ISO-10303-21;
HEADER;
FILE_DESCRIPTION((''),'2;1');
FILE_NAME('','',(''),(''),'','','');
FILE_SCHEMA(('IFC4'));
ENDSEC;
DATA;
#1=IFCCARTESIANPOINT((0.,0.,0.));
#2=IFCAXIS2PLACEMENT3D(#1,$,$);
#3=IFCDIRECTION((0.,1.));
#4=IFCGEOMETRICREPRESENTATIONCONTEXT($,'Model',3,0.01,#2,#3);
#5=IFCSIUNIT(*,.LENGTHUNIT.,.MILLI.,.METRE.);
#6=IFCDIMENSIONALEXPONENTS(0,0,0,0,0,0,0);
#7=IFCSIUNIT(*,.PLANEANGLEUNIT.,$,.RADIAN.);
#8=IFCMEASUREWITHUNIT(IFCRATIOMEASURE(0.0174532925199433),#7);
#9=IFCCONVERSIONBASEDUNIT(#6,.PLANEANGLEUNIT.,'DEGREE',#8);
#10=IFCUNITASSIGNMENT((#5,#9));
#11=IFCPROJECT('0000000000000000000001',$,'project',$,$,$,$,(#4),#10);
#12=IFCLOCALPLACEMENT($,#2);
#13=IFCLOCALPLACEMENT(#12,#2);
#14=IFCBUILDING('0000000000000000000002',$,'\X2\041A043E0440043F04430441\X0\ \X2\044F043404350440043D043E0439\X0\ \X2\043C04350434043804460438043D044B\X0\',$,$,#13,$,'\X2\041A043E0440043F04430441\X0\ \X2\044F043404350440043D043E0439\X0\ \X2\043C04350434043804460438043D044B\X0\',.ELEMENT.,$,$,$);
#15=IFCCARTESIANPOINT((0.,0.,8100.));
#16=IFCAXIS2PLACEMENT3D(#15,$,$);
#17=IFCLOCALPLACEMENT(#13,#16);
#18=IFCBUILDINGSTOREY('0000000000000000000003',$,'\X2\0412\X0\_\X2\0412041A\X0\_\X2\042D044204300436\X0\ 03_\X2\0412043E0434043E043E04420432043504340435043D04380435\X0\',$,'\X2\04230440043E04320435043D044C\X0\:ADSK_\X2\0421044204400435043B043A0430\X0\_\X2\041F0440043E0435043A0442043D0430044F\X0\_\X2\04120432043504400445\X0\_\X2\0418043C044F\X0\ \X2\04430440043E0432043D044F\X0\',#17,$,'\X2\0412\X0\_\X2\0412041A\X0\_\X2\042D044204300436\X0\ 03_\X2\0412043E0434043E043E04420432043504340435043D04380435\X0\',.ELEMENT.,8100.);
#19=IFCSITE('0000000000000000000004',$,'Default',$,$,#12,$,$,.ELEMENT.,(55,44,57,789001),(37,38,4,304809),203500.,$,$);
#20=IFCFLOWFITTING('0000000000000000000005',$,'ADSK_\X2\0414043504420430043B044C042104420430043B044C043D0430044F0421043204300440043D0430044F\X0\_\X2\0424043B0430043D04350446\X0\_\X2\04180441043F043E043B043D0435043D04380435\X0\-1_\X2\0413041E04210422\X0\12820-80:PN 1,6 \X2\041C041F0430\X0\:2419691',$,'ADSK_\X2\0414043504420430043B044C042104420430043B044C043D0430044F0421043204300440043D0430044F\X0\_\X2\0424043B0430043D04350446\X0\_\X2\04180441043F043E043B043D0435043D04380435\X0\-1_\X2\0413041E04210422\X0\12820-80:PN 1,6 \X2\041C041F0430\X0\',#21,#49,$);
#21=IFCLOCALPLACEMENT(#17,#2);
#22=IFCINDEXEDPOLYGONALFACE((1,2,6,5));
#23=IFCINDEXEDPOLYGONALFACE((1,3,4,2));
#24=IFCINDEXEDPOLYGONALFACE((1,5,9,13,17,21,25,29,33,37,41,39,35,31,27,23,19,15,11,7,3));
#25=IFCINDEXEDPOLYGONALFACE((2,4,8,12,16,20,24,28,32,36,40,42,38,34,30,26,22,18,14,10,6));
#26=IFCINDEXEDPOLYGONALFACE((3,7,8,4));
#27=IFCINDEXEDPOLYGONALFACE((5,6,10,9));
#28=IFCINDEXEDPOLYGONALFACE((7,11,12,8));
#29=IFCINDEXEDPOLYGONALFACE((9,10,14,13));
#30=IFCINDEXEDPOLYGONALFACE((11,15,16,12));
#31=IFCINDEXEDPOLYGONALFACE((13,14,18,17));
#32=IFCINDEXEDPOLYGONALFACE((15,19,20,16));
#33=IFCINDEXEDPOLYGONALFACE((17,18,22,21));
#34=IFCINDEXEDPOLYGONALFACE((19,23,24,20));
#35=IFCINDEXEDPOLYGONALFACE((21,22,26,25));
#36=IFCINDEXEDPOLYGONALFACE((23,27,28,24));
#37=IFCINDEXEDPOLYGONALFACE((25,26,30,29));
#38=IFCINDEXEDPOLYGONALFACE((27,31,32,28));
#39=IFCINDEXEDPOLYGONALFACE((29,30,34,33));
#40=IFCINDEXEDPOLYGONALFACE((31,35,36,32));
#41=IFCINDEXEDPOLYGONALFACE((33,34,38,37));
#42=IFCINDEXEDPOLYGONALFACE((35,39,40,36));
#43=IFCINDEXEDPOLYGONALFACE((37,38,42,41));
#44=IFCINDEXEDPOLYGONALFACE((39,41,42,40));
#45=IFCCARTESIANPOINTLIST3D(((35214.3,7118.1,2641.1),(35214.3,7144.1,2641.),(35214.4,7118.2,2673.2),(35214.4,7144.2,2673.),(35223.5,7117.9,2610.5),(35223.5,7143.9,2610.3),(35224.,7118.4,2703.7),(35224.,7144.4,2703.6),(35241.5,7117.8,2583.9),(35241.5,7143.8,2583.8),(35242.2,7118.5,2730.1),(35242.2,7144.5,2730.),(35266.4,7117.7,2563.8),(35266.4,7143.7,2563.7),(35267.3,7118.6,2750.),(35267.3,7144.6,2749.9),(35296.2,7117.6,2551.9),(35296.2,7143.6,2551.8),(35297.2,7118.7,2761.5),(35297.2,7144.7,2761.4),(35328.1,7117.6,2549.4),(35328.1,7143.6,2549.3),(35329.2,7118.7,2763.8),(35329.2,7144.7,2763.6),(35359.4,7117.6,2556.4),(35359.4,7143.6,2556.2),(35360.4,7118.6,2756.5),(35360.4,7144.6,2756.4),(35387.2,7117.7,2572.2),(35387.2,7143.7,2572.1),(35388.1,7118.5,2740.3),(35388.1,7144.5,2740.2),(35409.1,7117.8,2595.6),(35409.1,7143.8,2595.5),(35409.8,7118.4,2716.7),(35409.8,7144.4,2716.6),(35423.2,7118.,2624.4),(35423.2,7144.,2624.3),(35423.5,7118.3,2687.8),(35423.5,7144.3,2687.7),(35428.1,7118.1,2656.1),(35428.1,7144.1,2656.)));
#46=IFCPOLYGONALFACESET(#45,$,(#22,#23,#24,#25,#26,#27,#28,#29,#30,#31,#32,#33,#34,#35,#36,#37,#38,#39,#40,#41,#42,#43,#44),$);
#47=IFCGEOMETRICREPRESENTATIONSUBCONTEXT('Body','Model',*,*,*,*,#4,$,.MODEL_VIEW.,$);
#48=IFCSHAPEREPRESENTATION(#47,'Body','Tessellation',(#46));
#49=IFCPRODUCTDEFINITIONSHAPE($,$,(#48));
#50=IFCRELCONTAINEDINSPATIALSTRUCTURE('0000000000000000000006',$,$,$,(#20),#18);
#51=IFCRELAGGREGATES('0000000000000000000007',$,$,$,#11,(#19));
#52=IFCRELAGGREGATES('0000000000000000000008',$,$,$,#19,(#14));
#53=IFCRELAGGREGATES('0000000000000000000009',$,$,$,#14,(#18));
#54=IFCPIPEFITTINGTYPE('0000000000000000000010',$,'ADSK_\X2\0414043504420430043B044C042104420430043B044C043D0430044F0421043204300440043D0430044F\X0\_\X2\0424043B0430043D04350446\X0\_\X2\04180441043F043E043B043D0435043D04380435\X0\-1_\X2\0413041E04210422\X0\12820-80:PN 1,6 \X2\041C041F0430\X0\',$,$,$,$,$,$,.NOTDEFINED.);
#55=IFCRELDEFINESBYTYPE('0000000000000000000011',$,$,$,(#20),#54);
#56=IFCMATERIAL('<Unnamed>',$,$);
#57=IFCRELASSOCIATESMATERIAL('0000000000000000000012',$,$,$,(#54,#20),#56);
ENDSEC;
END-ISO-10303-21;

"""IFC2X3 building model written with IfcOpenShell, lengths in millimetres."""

from ifc_helpers import new_model, entity, si_unit, converted_unit, direction, frame, origin, origin_2d_with_axis, place, context, subcontext, project, spatial, circle, extrude, source, transform, mapped, material, type_object, type_shapes, element, save


model = new_model("IFC2X3")

# Units and contexts
model_context = context("Model", 3, precision=0.01, world=origin(), true_north=direction((0.0, 1.0)))
body_context = subcontext(model_context, "Body", "Model", "MODEL_VIEW")
ifc_project = project(units=[si_unit("LENGTHUNIT", "METRE", prefix="MILLI"), converted_unit("PLANEANGLEUNIT", "DEGREE", entity("IfcRatioMeasure", 0.0174532925199433), si_unit("PLANEANGLEUNIT", "RADIAN"), dimensions=[0, 0, 0, 0, 0, 0, 0])], contexts=[model_context])

# Site, building, storey
site_placement = place(None, origin())
site = spatial("IfcSite", under=ifc_project, at=site_placement, Name="Default", CompositionType="ELEMENT", RefLatitude=(55, 44, 57, 789001), RefLongitude=(37, 38, 4, 304809), RefElevation=203500.0)
building_placement = place(site_placement, origin())
building = spatial("IfcBuilding", under=site, at=building_placement, Name="Корпус ядерной медицины", LongName="Корпус ядерной медицины", CompositionType="ELEMENT")
storey_placement = place(building_placement, frame((0.0, 0.0, 8100.0)))
storey = spatial("IfcBuildingStorey", under=building, at=storey_placement, Name="В_ВК_Этаж 03_Водоотведение", ObjectType="Уровень:ADSK_Стрелка_Проектная_Вверх_Имя уровня", LongName="В_ВК_Этаж 03_Водоотведение", CompositionType="ELEMENT", Elevation=8100.0)

# Flow fitting
ifc_material = material(Name="<Unnamed>")
pipe_fitting_type_1 = type_object("IfcPipeFittingType", Name="ADSK_ДетальСтальнаяСварная_Фланец_Исполнение-1_ГОСТ12820-80:PN 1,6 МПа", PredefinedType="NOTDEFINED", material=ifc_material)
shared_shape_1 = source(origin(), body_context, "Body", "SweptSolid", [
    extrude(circle(Radius=107.5, at=origin_2d_with_axis()), frame((0.0, 0.0, 0.0), z_axis=(1.0, 0.0, 0.0), x_axis=(0.0, 1.0, 0.0)), (0.0, 0.0, 1.0), 26.0),
])
type_shapes(pipe_fitting_type_1, [shared_shape_1])
for number, where, z_axis, x_axis, name in (
    (1, (35320.6, 7144.1, 2656.5), (0.005, 0.005, 0.999975), (0.0, -0.999988, 0.005), "ADSK_ДетальСтальнаяСварная_Фланец_Исполнение-1_ГОСТ12820-80:PN 1,6 МПа:2419691"),
):
    element("IfcFlowFitting", number, at=place(storey_placement, frame(where, z_axis=z_axis, x_axis=x_axis)), inside=storey, type_object=pipe_fitting_type_1, material=ifc_material, Name=name, ObjectType="ADSK_ДетальСтальнаяСварная_Фланец_Исполнение-1_ГОСТ12820-80:PN 1,6 МПа", context=body_context, shape_type="MappedRepresentation", body=[
        mapped(shared_shape_1, transform((0.0, 0.0, 0.0), scale=1.0)),
    ])

save(model, "model.ifc")
